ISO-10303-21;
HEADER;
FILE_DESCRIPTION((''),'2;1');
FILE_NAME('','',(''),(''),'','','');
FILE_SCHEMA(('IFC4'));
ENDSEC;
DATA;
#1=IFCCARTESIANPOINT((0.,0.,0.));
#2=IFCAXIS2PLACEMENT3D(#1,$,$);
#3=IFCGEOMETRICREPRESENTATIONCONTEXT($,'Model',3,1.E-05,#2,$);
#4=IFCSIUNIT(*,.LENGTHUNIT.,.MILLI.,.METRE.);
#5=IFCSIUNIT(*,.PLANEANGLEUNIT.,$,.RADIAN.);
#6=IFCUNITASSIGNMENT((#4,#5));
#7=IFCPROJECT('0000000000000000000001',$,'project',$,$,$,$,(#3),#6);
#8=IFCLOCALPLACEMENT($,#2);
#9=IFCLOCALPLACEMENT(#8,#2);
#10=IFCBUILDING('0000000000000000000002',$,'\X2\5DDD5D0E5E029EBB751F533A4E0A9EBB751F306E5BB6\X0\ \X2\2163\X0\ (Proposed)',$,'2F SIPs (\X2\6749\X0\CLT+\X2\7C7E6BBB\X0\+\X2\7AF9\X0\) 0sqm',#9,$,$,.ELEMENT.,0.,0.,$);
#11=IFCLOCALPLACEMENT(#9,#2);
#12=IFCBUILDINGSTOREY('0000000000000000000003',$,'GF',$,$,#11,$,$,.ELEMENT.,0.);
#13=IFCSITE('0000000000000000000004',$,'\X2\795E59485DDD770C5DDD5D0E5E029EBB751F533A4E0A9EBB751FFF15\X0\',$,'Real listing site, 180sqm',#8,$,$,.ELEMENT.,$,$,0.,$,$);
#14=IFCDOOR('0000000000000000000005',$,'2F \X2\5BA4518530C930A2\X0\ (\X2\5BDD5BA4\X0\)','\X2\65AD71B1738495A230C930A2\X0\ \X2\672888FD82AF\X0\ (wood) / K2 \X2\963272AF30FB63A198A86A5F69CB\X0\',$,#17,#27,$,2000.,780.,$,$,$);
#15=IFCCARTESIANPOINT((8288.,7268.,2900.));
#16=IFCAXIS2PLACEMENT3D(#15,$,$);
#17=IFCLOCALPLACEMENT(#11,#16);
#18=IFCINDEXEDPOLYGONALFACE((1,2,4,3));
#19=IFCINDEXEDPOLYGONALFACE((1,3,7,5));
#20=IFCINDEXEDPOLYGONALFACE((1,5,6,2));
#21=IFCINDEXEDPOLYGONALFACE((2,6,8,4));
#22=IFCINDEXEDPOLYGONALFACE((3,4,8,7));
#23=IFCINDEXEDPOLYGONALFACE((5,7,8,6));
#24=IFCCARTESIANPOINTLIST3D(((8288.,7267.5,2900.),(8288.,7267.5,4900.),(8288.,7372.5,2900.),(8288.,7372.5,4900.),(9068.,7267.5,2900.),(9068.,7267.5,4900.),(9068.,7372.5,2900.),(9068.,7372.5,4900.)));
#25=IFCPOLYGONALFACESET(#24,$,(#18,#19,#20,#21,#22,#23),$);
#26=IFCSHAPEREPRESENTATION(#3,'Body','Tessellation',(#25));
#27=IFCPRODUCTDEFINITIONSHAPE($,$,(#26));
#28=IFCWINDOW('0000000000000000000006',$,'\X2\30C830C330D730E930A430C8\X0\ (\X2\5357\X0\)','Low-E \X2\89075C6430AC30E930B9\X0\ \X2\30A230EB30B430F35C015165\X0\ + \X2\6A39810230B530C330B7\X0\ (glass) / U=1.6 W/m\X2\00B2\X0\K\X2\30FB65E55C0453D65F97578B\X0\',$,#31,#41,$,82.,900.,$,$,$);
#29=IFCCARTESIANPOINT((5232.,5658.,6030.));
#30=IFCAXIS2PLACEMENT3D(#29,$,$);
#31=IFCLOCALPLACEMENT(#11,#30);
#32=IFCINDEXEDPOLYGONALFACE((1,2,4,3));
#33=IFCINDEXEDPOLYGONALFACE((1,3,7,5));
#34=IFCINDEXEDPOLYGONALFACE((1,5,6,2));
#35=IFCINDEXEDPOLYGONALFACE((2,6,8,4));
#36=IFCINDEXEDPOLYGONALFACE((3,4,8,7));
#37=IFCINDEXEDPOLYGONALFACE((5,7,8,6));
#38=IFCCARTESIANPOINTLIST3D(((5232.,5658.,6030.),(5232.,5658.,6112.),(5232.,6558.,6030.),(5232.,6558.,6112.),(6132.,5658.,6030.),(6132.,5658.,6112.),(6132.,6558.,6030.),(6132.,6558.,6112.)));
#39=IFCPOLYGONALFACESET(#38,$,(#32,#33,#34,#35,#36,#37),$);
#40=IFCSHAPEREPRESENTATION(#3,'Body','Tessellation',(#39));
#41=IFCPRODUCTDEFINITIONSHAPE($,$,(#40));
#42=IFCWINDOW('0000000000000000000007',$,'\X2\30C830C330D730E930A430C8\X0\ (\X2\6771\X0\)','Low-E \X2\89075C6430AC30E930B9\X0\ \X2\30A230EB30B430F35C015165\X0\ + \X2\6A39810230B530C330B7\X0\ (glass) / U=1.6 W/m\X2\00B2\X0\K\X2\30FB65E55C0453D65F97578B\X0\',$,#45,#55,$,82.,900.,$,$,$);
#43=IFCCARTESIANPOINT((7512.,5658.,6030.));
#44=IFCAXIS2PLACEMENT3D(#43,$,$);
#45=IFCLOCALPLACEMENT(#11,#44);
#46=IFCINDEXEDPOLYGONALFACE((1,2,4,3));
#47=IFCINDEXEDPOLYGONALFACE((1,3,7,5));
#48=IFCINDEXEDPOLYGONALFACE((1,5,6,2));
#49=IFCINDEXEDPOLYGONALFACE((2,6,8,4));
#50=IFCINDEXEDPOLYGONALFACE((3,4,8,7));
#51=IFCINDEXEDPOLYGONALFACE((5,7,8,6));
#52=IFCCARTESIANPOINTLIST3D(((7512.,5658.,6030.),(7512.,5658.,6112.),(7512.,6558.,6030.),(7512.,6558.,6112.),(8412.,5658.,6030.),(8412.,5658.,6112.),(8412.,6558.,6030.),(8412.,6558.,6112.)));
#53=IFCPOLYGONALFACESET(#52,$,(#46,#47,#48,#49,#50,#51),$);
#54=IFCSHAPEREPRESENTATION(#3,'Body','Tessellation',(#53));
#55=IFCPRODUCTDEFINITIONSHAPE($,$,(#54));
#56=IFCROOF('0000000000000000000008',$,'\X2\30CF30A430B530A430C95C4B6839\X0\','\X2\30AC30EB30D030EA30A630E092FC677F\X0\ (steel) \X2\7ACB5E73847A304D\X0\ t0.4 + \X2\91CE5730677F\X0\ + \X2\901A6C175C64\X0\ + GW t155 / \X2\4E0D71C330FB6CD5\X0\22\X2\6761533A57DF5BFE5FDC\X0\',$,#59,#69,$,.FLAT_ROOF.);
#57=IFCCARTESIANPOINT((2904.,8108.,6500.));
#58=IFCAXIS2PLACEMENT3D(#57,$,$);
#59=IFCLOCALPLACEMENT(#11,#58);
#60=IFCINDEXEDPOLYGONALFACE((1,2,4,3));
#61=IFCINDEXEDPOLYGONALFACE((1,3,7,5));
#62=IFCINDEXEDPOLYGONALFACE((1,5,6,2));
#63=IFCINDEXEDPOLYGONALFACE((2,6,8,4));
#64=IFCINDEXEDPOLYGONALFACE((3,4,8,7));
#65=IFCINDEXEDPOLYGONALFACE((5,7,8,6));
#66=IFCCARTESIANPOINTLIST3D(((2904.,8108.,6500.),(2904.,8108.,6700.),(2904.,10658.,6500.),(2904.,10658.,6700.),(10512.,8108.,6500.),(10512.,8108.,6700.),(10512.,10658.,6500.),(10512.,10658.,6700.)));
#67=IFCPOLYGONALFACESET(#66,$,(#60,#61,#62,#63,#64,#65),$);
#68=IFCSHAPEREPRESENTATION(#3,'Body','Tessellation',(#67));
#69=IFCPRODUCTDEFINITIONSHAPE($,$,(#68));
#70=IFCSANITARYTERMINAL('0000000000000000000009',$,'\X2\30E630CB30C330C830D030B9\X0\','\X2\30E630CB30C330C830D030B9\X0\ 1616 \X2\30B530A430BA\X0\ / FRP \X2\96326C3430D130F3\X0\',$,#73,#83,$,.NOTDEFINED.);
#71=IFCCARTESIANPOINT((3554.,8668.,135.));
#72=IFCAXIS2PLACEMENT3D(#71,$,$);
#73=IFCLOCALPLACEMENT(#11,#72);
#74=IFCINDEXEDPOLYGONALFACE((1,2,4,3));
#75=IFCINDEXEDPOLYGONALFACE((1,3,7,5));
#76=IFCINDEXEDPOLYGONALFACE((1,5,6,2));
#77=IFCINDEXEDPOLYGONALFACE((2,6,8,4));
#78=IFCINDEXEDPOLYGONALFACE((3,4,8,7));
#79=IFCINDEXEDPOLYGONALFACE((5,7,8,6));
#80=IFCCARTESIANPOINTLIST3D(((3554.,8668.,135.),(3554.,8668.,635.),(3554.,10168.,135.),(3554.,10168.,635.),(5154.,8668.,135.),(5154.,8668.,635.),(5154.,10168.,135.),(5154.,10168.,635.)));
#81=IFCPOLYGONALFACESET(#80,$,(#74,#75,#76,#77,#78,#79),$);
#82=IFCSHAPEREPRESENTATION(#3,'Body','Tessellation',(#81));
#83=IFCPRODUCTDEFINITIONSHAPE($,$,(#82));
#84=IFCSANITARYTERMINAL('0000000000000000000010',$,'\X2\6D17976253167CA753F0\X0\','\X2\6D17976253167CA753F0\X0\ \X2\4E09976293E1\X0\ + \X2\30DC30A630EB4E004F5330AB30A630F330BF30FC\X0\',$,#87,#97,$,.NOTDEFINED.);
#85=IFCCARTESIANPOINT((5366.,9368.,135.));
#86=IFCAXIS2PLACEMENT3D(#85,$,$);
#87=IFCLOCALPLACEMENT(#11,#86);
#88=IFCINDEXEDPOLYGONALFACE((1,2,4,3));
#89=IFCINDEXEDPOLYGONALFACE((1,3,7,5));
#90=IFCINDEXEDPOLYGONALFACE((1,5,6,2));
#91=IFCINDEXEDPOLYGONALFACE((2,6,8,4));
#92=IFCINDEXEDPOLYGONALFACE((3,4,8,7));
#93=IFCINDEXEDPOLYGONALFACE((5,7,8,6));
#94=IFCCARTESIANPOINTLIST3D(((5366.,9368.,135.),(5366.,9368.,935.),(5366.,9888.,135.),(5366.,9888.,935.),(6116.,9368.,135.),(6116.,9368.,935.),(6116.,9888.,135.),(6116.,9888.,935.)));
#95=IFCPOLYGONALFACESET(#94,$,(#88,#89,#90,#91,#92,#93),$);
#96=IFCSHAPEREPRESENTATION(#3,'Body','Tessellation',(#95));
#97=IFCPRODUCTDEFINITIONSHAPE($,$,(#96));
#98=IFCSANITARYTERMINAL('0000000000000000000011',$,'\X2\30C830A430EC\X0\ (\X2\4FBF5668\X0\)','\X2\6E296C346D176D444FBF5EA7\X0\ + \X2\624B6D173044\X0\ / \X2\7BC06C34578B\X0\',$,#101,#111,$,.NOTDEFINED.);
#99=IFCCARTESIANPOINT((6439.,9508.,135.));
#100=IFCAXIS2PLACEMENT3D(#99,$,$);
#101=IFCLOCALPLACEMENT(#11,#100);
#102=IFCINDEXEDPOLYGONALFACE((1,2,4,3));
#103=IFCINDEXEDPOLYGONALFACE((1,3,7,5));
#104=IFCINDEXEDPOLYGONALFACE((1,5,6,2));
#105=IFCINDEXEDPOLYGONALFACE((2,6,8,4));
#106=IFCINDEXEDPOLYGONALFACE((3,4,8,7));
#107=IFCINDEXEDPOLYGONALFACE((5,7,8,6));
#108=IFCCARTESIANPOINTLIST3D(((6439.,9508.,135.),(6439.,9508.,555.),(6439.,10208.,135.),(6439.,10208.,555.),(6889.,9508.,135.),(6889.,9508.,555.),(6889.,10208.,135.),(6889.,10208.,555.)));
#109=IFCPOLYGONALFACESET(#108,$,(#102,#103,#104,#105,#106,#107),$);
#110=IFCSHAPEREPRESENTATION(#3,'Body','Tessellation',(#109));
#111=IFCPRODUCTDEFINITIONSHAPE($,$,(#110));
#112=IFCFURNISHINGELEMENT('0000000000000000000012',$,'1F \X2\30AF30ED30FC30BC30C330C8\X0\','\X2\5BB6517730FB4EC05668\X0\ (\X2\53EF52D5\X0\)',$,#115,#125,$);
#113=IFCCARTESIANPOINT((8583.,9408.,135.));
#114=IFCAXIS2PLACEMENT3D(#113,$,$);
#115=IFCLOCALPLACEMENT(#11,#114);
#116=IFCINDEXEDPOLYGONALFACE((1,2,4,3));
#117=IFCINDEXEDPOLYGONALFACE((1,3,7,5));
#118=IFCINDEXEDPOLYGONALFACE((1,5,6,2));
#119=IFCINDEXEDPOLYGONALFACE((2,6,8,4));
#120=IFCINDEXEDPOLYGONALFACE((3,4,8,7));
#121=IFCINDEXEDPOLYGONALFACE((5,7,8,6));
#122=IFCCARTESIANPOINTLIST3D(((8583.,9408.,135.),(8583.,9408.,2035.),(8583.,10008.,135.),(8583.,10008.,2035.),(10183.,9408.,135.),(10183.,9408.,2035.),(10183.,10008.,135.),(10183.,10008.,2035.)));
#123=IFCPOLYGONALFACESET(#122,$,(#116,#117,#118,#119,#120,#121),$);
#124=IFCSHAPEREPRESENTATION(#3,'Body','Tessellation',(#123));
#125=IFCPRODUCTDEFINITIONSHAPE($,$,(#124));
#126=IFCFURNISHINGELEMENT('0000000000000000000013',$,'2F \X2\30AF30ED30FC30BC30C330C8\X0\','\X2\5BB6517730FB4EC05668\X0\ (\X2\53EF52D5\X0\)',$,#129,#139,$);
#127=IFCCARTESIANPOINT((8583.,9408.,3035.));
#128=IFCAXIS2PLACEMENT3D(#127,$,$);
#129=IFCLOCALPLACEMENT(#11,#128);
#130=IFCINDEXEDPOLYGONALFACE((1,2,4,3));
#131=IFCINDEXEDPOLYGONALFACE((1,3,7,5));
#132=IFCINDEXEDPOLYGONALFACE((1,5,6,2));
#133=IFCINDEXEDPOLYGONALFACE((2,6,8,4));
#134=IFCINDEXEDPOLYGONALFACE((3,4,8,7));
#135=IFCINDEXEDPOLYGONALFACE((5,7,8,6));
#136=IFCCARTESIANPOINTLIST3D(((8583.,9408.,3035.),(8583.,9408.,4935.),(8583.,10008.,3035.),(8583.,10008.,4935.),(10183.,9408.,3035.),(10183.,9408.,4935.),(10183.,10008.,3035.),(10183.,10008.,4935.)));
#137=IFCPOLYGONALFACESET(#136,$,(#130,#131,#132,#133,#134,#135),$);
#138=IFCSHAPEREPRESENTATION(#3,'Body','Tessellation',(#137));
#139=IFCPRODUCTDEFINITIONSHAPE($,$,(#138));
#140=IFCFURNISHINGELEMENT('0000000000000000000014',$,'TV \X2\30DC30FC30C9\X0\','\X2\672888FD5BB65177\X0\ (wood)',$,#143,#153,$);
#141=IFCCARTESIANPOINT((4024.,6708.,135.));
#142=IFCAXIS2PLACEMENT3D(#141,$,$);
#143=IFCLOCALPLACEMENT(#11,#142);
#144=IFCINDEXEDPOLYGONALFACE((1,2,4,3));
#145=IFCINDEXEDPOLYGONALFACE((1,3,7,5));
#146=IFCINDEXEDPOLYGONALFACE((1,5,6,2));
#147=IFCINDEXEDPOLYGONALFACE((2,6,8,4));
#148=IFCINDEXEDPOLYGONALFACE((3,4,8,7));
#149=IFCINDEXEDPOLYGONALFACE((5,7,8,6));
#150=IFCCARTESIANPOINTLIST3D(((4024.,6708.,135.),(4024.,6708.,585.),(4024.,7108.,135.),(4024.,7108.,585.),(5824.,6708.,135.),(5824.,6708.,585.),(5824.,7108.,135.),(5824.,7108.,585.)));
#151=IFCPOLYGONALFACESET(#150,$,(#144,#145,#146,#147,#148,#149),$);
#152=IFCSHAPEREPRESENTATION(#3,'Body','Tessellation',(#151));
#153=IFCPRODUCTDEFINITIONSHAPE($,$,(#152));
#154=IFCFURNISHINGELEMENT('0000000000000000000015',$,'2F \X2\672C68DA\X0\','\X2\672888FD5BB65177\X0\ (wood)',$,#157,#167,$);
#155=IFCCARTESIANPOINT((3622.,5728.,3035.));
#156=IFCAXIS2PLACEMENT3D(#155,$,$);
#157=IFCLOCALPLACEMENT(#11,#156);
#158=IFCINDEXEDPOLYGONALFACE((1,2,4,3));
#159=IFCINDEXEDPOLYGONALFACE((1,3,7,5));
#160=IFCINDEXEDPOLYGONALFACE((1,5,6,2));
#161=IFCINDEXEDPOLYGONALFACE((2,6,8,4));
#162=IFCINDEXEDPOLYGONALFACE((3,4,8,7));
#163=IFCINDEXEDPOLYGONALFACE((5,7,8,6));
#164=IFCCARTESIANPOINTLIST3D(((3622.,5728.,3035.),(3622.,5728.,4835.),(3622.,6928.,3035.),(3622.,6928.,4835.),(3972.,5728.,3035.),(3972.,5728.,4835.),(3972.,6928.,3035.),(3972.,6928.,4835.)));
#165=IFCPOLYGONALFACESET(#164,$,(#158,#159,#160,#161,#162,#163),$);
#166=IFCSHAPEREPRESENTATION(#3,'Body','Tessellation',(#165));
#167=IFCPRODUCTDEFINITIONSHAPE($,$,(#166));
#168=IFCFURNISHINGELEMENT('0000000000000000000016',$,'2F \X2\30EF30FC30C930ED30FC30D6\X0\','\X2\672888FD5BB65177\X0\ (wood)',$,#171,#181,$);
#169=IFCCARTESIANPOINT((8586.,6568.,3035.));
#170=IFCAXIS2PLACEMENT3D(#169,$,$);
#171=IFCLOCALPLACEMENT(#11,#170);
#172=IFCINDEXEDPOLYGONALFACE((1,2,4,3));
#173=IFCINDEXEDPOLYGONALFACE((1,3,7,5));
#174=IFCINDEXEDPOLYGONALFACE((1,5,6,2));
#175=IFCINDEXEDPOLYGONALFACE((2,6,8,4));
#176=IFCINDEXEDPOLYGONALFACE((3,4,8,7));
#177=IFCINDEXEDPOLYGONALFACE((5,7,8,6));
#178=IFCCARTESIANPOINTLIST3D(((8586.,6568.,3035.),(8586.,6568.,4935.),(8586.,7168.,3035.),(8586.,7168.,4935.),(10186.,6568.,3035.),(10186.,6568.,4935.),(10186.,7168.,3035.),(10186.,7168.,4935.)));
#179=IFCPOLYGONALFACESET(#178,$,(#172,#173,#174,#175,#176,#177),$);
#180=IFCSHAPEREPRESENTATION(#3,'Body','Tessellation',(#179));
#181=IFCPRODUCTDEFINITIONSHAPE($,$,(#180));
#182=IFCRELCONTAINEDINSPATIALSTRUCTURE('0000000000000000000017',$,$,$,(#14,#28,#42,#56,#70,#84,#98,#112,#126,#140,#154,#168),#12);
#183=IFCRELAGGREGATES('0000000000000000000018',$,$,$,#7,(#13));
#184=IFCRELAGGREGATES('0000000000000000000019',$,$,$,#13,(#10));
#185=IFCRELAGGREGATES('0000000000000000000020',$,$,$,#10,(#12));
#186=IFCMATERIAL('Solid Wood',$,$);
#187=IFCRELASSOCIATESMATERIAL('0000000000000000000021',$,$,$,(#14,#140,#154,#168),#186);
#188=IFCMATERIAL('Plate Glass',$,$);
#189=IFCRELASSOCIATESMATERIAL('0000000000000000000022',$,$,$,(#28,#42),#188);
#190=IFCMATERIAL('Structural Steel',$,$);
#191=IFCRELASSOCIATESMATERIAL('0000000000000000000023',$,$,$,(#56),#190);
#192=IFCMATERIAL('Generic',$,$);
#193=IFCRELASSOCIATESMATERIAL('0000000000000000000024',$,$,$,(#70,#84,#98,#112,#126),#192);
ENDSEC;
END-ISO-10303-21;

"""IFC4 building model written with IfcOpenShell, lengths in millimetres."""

from ifc_helpers import new_model, si_unit, frame, frame_2d, origin, place, context, project, spatial, rectangle, extrude, material, element, save


model = new_model("IFC4")

# Units and contexts
model_context = context("Model", 3, precision=1e-05, world=origin())
ifc_project = project(units=[si_unit("LENGTHUNIT", "METRE", prefix="MILLI"), si_unit("PLANEANGLEUNIT", "RADIAN")], contexts=[model_context])

# Site, building, storey
site_placement = place(None, origin())
site = spatial("IfcSite", under=ifc_project, at=site_placement, Name="神奈川県川崎市麻生区上麻生５", ObjectType="Real listing site, 180sqm", CompositionType="ELEMENT", RefElevation=0.0)
building_placement = place(site_placement, origin())
building = spatial("IfcBuilding", under=site, at=building_placement, Name="川崎市麻生区上麻生の家 Ⅳ (Proposed)", ObjectType="2F SIPs (杉CLT+籾殻+竹) 0sqm", CompositionType="ELEMENT", ElevationOfRefHeight=0.0, ElevationOfTerrain=0.0)
storey_placement = place(building_placement, origin())
storey = spatial("IfcBuildingStorey", under=building, at=storey_placement, Name="GF", CompositionType="ELEMENT", Elevation=0.0)

# Shared definitions
ifc_material_1 = material(Name="Solid Wood")
ifc_material_2 = material(Name="Plate Glass")

# Door
door_1_placement = place(storey_placement, frame((8288.0, 7268.0, 2900.0)))
element("IfcDoor", 1, at=door_1_placement, inside=storey, material=ifc_material_1, Name="2F 室内ドア (寝室)", Description="断熱玄関ドア 木製芯 (wood) / K2 防犯・採風機構", OverallHeight=2000.0, OverallWidth=780.0, context=model_context, shape_type="SweptSolid", body=[
    extrude(rectangle(XDim=780.0, YDim=105.0, at=frame_2d((390.0, 52.0))), frame((8288.0, 7268.0, 2900.0)), (0.0, 0.0, 1.0), 2000.0),
])

# Windows
window_1_placement = place(storey_placement, frame((5232.0, 5658.0, 6030.0)))
element("IfcWindow", 2, at=window_1_placement, inside=storey, material=ifc_material_2, Name="トップライト (南)", Description="Low-E 複層ガラス アルゴン封入 + 樹脂サッシ (glass) / U=1.6 W/m²K・日射取得型", OverallHeight=82.0, OverallWidth=900.0, context=model_context, shape_type="SweptSolid", body=[
    extrude(rectangle(XDim=900.0, YDim=900.0, at=frame_2d((450.0, 450.0))), frame((5232.0, 5658.0, 6030.0)), (0.0, 0.0, 1.0), 82.0),
])
window_2_placement = place(storey_placement, frame((7512.0, 5658.0, 6030.0)))
element("IfcWindow", 3, at=window_2_placement, inside=storey, material=ifc_material_2, Name="トップライト (東)", Description="Low-E 複層ガラス アルゴン封入 + 樹脂サッシ (glass) / U=1.6 W/m²K・日射取得型", OverallHeight=82.0, OverallWidth=900.0, context=model_context, shape_type="SweptSolid", body=[
    extrude(rectangle(XDim=900.0, YDim=900.0, at=frame_2d((450.0, 450.0))), frame((7512.0, 5658.0, 6030.0)), (0.0, 0.0, 1.0), 82.0),
])

# Roof
ifc_material_3 = material(Name="Structural Steel")
roof_placement = place(storey_placement, frame((2904.0, 8108.0, 6500.0)))
element("IfcRoof", 4, at=roof_placement, inside=storey, material=ifc_material_3, Name="ハイサイド屋根", Description="ガルバリウム鋼板 (steel) 立平葺き t0.4 + 野地板 + 通気層 + GW t155 / 不燃・法22条区域対応", PredefinedType="FLAT_ROOF", context=model_context, shape_type="SweptSolid", body=[
    extrude(rectangle(XDim=7608.0, YDim=2550.0, at=frame_2d((3804.0, 1275.0))), frame((2904.0, 8108.0, 6500.0)), (0.0, 0.0, 1.0), 200.0),
])

# Sanitary terminals
ifc_material_4 = material(Name="Generic")
sanitary_terminal_1_placement = place(storey_placement, frame((3554.0, 8668.0, 135.0)))
element("IfcSanitaryTerminal", 5, at=sanitary_terminal_1_placement, inside=storey, material=ifc_material_4, Name="ユニットバス", Description="ユニットバス 1616 サイズ / FRP 防水パン", PredefinedType="NOTDEFINED", context=model_context, shape_type="SweptSolid", body=[
    extrude(rectangle(XDim=1600.0, YDim=1500.0, at=frame_2d((800.0, 750.0))), frame((3554.0, 8668.0, 135.0)), (0.0, 0.0, 1.0), 500.0),
])
sanitary_terminal_2_placement = place(storey_placement, frame((5366.0, 9368.0, 135.0)))
element("IfcSanitaryTerminal", 6, at=sanitary_terminal_2_placement, inside=storey, material=ifc_material_4, Name="洗面化粧台", Description="洗面化粧台 三面鏡 + ボウル一体カウンター", PredefinedType="NOTDEFINED", context=model_context, shape_type="SweptSolid", body=[
    extrude(rectangle(XDim=750.0, YDim=520.0, at=frame_2d((375.0, 260.0))), frame((5366.0, 9368.0, 135.0)), (0.0, 0.0, 1.0), 800.0),
])
sanitary_terminal_3_placement = place(storey_placement, frame((6439.0, 9508.0, 135.0)))
element("IfcSanitaryTerminal", 7, at=sanitary_terminal_3_placement, inside=storey, material=ifc_material_4, Name="トイレ (便器)", Description="温水洗浄便座 + 手洗い / 節水型", PredefinedType="NOTDEFINED", context=model_context, shape_type="SweptSolid", body=[
    extrude(rectangle(XDim=450.0, YDim=700.0, at=frame_2d((225.0, 350.0))), frame((6439.0, 9508.0, 135.0)), (0.0, 0.0, 1.0), 420.0),
])

# Furnishing elements
furnishing_1_placement = place(storey_placement, frame((8583.0, 9408.0, 135.0)))
element("IfcFurnishingElement", 8, at=furnishing_1_placement, inside=storey, material=ifc_material_4, Name="1F クローゼット", Description="家具・什器 (可動)", context=model_context, shape_type="SweptSolid", body=[
    extrude(rectangle(XDim=1600.0, YDim=600.0, at=frame_2d((800.0, 300.0))), frame((8583.0, 9408.0, 135.0)), (0.0, 0.0, 1.0), 1900.0),
])
furnishing_2_placement = place(storey_placement, frame((8583.0, 9408.0, 3035.0)))
element("IfcFurnishingElement", 9, at=furnishing_2_placement, inside=storey, material=ifc_material_4, Name="2F クローゼット", Description="家具・什器 (可動)", context=model_context, shape_type="SweptSolid", body=[
    extrude(rectangle(XDim=1600.0, YDim=600.0, at=frame_2d((800.0, 300.0))), frame((8583.0, 9408.0, 3035.0)), (0.0, 0.0, 1.0), 1900.0),
])
furnishing_3_placement = place(storey_placement, frame((4024.0, 6708.0, 135.0)))
element("IfcFurnishingElement", 10, at=furnishing_3_placement, inside=storey, material=ifc_material_1, Name="TV ボード", Description="木製家具 (wood)", context=model_context, shape_type="SweptSolid", body=[
    extrude(rectangle(XDim=1800.0, YDim=400.0, at=frame_2d((900.0, 200.0))), frame((4024.0, 6708.0, 135.0)), (0.0, 0.0, 1.0), 450.0),
])
furnishing_4_placement = place(storey_placement, frame((3622.0, 5728.0, 3035.0)))
element("IfcFurnishingElement", 11, at=furnishing_4_placement, inside=storey, material=ifc_material_1, Name="2F 本棚", Description="木製家具 (wood)", context=model_context, shape_type="SweptSolid", body=[
    extrude(rectangle(XDim=350.0, YDim=1200.0, at=frame_2d((175.0, 600.0))), frame((3622.0, 5728.0, 3035.0)), (0.0, 0.0, 1.0), 1800.0),
])
furnishing_5_placement = place(storey_placement, frame((8586.0, 6568.0, 3035.0)))
element("IfcFurnishingElement", 12, at=furnishing_5_placement, inside=storey, material=ifc_material_1, Name="2F ワードローブ", Description="木製家具 (wood)", context=model_context, shape_type="SweptSolid", body=[
    extrude(rectangle(XDim=1600.0, YDim=600.0, at=frame_2d((800.0, 300.0))), frame((8586.0, 6568.0, 3035.0)), (0.0, 0.0, 1.0), 1900.0),
])

save(model, "model.ifc")
